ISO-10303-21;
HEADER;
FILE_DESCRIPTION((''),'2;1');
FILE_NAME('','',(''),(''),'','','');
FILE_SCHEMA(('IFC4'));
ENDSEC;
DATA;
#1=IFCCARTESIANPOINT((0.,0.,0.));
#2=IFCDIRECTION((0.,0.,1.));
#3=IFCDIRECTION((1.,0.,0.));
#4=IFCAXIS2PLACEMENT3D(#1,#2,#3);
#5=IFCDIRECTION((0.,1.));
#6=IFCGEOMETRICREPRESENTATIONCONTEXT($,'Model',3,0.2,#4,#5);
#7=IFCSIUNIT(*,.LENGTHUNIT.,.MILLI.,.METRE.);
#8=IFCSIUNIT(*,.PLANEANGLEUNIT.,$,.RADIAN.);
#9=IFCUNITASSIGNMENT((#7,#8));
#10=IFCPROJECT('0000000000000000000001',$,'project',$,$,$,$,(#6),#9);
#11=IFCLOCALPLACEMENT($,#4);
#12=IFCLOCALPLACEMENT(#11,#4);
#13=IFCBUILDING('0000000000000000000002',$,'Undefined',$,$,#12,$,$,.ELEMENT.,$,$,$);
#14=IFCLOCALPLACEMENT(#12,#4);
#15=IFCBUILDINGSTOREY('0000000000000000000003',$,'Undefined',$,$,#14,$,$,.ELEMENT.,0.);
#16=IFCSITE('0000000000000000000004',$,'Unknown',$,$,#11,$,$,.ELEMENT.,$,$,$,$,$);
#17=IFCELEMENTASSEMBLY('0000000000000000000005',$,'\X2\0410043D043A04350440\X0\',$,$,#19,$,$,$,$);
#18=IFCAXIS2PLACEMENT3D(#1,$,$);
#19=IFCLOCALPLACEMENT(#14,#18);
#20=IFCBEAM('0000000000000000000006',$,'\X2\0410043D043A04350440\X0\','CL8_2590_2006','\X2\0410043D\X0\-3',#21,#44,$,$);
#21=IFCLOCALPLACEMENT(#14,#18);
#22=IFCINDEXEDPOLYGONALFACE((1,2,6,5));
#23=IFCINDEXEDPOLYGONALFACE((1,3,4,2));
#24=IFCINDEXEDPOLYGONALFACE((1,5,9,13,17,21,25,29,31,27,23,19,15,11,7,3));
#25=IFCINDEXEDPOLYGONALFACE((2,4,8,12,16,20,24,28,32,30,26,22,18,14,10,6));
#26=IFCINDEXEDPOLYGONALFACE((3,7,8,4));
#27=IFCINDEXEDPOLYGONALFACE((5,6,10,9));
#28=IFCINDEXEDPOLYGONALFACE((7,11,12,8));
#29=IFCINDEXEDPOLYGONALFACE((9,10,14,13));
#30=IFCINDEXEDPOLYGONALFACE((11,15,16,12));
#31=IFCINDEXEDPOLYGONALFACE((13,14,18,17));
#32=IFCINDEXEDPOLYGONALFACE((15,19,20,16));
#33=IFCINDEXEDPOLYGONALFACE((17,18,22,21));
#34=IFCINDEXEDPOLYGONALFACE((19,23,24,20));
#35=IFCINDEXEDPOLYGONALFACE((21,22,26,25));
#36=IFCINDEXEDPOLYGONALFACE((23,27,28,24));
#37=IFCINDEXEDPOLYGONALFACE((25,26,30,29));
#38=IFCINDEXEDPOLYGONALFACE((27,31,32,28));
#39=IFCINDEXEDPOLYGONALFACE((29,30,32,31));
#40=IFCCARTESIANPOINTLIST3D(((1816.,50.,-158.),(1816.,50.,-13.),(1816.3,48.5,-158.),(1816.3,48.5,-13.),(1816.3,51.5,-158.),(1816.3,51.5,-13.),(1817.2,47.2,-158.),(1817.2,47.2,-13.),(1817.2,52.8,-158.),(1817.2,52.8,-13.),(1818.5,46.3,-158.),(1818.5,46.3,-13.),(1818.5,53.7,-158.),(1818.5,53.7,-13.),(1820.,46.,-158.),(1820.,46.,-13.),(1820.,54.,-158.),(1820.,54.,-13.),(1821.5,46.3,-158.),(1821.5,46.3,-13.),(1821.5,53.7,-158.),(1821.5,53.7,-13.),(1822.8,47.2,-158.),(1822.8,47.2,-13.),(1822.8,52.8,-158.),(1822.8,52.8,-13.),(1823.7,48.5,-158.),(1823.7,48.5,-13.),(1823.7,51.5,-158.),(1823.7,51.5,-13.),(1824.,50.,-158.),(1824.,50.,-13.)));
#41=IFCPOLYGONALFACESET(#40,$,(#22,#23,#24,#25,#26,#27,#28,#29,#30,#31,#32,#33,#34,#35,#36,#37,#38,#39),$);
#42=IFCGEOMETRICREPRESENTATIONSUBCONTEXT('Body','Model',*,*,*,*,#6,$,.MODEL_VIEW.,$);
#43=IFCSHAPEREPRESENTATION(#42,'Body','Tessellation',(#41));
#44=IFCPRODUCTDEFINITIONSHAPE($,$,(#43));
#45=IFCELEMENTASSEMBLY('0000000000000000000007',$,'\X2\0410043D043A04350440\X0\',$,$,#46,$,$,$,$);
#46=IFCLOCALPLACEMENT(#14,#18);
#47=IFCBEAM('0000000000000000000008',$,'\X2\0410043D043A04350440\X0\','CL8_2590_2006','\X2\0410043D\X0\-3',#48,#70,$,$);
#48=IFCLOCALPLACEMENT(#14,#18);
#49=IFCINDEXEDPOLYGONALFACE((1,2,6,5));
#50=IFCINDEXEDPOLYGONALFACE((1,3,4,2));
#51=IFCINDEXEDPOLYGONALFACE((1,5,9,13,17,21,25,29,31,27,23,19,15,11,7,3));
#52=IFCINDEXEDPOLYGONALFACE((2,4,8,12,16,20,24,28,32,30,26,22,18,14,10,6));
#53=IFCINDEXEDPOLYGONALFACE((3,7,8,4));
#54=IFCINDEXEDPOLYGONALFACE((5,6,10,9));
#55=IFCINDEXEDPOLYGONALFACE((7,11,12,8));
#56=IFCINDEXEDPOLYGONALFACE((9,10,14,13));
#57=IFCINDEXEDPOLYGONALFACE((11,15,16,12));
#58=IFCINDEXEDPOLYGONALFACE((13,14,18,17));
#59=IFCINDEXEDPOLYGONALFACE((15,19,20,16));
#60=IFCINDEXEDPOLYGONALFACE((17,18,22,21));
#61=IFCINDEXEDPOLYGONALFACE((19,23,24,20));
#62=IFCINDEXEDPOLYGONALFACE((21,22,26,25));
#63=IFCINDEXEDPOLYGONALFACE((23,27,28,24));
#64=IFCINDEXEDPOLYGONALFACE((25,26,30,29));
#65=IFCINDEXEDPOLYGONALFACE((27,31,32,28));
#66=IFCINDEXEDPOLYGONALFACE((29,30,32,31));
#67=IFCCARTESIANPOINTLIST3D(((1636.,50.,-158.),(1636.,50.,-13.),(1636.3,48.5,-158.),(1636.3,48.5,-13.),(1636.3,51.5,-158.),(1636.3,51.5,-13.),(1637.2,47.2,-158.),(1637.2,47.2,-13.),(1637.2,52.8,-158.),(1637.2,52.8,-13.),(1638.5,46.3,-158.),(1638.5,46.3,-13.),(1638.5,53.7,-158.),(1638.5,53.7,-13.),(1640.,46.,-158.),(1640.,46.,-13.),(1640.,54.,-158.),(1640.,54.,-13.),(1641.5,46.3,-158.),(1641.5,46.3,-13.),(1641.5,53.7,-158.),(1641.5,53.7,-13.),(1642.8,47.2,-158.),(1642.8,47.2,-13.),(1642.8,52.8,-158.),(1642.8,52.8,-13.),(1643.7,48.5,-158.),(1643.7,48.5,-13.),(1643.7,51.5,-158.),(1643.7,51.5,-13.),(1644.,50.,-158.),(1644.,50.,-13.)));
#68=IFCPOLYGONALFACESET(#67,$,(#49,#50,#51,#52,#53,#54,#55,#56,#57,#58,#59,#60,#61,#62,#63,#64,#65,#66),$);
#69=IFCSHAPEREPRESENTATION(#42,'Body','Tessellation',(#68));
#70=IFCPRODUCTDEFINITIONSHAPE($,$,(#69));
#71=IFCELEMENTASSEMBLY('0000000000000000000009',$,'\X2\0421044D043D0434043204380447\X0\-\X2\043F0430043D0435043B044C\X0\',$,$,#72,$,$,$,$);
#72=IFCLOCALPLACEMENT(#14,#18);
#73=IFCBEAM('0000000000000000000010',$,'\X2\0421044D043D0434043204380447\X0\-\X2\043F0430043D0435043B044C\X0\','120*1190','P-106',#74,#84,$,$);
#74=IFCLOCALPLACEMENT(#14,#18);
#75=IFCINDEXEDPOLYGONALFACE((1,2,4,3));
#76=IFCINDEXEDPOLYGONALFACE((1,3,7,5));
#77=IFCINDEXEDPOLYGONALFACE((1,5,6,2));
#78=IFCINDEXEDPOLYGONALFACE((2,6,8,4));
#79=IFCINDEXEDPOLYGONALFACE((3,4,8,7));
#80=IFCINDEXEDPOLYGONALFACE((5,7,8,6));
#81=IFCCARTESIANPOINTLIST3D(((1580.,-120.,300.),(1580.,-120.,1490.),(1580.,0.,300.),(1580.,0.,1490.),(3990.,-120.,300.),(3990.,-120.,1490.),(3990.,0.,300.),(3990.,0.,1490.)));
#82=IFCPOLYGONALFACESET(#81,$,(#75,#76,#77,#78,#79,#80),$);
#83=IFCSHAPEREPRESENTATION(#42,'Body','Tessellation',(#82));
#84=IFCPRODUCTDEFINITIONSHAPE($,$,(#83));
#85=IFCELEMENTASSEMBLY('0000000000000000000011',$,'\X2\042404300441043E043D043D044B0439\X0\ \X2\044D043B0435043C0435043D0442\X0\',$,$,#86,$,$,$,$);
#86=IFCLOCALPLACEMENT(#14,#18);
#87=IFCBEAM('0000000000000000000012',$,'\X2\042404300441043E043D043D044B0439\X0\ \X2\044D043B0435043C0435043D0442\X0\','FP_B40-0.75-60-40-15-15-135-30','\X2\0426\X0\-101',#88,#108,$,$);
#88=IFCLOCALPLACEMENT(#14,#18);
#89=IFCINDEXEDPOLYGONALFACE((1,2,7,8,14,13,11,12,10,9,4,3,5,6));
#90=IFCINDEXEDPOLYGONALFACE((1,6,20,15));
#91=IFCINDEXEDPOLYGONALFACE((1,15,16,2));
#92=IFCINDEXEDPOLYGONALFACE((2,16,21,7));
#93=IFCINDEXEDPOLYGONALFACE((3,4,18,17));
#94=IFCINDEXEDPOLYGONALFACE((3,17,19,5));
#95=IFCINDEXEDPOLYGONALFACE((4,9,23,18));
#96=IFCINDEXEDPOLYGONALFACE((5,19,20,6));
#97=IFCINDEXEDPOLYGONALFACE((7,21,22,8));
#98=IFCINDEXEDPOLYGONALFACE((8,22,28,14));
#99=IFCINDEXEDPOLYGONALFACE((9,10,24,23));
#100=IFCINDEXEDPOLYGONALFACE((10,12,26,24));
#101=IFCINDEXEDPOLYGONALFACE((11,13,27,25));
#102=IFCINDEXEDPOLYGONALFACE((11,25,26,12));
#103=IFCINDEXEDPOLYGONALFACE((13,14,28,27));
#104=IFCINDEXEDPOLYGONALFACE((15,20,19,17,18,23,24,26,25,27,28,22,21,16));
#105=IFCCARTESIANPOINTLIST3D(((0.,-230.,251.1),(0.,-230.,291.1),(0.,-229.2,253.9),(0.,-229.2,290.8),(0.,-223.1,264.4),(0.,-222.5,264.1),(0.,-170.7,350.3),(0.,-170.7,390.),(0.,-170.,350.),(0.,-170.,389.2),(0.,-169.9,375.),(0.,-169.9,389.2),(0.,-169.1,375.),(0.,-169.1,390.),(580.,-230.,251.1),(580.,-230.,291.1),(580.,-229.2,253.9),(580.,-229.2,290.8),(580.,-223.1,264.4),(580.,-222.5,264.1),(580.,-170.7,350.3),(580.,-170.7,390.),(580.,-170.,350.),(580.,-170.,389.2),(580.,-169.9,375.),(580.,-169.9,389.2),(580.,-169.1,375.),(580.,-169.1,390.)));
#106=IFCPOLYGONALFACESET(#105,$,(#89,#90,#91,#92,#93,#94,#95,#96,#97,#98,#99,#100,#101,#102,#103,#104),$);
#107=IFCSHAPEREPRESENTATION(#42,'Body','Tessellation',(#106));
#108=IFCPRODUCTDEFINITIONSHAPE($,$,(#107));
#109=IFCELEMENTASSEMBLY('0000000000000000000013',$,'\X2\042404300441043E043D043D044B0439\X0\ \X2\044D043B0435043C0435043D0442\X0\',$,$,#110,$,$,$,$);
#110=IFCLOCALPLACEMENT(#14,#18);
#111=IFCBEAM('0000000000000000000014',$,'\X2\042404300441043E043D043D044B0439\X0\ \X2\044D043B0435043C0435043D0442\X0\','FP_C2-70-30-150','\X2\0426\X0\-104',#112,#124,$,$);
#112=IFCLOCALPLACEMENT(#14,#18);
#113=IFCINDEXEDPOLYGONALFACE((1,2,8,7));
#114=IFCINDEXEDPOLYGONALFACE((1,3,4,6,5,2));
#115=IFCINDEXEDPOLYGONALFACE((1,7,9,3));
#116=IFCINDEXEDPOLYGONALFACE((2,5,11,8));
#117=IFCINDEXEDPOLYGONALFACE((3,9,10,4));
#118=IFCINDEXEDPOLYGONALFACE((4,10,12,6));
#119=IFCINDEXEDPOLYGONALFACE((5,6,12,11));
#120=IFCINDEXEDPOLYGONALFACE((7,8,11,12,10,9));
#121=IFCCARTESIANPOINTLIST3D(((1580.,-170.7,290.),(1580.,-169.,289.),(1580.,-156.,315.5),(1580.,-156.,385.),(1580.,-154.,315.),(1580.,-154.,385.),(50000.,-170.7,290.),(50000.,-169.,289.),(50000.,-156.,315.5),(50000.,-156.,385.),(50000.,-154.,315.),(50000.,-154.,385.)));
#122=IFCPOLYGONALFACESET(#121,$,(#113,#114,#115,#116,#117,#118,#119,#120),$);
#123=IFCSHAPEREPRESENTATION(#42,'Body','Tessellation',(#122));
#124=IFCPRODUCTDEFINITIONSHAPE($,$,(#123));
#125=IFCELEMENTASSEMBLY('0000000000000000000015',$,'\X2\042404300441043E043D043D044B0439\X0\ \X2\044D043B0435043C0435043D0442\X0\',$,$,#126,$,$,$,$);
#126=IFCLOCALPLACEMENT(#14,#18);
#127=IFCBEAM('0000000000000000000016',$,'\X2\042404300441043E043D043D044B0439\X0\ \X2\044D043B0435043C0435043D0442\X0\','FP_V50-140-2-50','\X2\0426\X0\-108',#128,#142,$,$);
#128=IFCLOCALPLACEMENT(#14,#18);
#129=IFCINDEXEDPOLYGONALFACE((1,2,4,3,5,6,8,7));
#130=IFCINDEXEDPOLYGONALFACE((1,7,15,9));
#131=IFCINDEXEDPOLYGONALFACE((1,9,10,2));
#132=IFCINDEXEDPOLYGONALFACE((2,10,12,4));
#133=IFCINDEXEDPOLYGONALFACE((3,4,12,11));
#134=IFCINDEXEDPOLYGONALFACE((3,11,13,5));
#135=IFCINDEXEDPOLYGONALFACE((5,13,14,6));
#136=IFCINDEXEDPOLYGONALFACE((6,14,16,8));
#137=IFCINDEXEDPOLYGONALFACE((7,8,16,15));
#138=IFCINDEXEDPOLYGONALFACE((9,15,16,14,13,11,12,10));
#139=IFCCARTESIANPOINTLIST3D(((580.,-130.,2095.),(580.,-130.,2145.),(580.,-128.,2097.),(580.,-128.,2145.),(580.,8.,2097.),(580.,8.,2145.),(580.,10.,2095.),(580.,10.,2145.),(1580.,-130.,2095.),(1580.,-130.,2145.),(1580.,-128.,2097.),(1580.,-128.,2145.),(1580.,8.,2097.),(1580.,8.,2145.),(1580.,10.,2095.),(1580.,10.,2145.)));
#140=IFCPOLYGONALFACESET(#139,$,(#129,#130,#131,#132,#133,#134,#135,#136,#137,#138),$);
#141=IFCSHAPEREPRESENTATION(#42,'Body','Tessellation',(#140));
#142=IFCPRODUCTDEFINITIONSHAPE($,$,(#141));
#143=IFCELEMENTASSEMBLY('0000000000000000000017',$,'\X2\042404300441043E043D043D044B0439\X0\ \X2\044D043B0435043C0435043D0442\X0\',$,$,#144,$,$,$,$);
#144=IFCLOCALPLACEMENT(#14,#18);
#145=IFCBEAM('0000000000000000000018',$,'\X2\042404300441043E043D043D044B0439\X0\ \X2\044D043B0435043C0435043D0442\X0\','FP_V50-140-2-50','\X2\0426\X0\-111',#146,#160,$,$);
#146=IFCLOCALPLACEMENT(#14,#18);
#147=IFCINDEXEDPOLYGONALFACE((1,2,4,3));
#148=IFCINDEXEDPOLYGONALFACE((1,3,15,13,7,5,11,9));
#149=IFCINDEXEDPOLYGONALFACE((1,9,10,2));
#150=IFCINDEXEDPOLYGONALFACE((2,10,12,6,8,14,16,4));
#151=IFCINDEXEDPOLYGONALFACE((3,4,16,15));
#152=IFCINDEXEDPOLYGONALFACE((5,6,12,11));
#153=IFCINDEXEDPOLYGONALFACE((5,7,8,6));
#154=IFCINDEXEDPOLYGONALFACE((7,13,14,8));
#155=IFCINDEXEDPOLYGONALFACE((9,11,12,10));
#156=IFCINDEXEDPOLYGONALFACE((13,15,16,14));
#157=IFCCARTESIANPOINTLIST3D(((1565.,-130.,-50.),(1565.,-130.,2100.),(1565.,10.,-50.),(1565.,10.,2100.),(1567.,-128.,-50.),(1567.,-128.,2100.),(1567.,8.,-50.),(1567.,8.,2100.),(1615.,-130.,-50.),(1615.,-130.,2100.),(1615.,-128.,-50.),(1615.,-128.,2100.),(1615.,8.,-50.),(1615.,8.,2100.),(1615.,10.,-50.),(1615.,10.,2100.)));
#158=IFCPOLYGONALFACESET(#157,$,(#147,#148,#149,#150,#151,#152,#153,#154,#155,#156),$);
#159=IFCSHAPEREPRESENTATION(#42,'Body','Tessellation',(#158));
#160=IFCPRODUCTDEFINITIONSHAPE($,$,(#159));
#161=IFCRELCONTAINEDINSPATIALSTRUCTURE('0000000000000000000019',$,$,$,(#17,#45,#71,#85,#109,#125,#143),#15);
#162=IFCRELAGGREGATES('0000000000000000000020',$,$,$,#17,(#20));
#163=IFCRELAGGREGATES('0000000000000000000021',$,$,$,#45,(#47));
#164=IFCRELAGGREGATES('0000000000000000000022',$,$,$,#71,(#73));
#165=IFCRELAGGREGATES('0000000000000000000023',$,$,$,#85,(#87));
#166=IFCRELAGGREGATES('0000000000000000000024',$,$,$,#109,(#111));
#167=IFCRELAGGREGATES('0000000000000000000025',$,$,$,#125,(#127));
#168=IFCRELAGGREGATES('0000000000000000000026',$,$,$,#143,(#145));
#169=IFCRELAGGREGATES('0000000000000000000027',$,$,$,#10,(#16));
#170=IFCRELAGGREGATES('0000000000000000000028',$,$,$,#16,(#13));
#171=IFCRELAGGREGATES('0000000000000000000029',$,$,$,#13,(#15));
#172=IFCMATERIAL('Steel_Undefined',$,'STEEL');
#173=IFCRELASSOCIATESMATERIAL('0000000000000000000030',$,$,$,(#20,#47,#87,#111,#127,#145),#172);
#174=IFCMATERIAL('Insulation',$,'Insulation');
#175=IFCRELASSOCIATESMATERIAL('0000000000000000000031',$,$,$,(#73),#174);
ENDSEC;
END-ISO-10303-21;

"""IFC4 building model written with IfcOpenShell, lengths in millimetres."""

from ifc_helpers import new_model, si_unit, direction, frame, origin_with_axes, place, context, subcontext, project, spatial, line, indexed_curve, outline, extrude, material, element, aggregate, save


model = new_model("IFC4")

# Units and contexts
model_context = context("Model", 3, precision=0.2, world=origin_with_axes(), true_north=direction((0.0, 1.0)))
body_context = subcontext(model_context, "Body", "Model", "MODEL_VIEW")
ifc_project = project(units=[si_unit("LENGTHUNIT", "METRE", prefix="MILLI"), si_unit("PLANEANGLEUNIT", "RADIAN")], contexts=[model_context])

# Site, building, storey
site_placement = place(None, origin_with_axes())
site = spatial("IfcSite", under=ifc_project, at=site_placement, Name="Unknown", CompositionType="ELEMENT")
building_placement = place(site_placement, origin_with_axes())
building = spatial("IfcBuilding", under=site, at=building_placement, Name="Undefined", CompositionType="ELEMENT")
storey_placement = place(building_placement, origin_with_axes())
storey = spatial("IfcBuildingStorey", under=building, at=storey_placement, Name="Undefined", CompositionType="ELEMENT", Elevation=0.0)

# Shared definitions
ifc_material_1 = material(Name="Steel_Undefined", Category="STEEL")

# Element assemblies, beams
assembly_1_placement = place(storey_placement, frame((1820.0, 50.0, -13.0), z_axis=(1.0, 0.0, 0.0), x_axis=(0.0, 0.0, -1.0)))
assembly_1 = element("IfcElementAssembly", 1, at=assembly_1_placement, inside=storey, Name="Анкер")
beam_1_placement = place(assembly_1_placement, origin_with_axes())
beam_1 = element("IfcBeam", 2, at=beam_1_placement, material=ifc_material_1, Name="Анкер", Description="CL8_2590_2006", ObjectType="Ан-3", context=body_context, shape_type="SolidModel", body=[
    extrude(outline(indexed_curve([(4.0, 0.0), (3.7, 1.5), (2.8, 2.8), (1.5, 3.7), (0.0, 4.0), (-1.5, 3.7), (-2.8, 2.8), (-3.7, 1.5), (-4.0, 0.0), (-3.7, -1.5), (-2.8, -2.8), (-1.5, -3.7), (0.0, -4.0), (1.5, -3.7), (2.8, -2.8), (3.7, -1.5)], segments=[line(1, 2, 3, 4, 5, 6, 7, 8, 9, 10, 11, 12, 13, 14, 15, 16, 1)])), frame((0.0, 0.0, 0.0), z_axis=(-1.0, 0.0, 0.0), x_axis=(0.0, 0.0, 1.0)), (0.0, 0.0, -1.0), 145.0),
])
aggregate(assembly_1, [beam_1])
assembly_2_placement = place(storey_placement, frame((1640.0, 50.0, -13.0), z_axis=(1.0, 0.0, 0.0), x_axis=(0.0, 0.0, -1.0)))
assembly_2 = element("IfcElementAssembly", 3, at=assembly_2_placement, inside=storey, Name="Анкер")
beam_2_placement = place(assembly_2_placement, origin_with_axes())
beam_2 = element("IfcBeam", 4, at=beam_2_placement, material=ifc_material_1, Name="Анкер", Description="CL8_2590_2006", ObjectType="Ан-3", context=body_context, shape_type="SolidModel", body=[
    extrude(outline(indexed_curve([(4.0, 0.0), (3.7, 1.5), (2.8, 2.8), (1.5, 3.7), (0.0, 4.0), (-1.5, 3.7), (-2.8, 2.8), (-3.7, 1.5), (-4.0, 0.0), (-3.7, -1.5), (-2.8, -2.8), (-1.5, -3.7), (0.0, -4.0), (1.5, -3.7), (2.8, -2.8), (3.7, -1.5)], segments=[line(1, 2, 3, 4, 5, 6, 7, 8, 9, 10, 11, 12, 13, 14, 15, 16, 1)])), frame((0.0, 0.0, 0.0), z_axis=(-1.0, 0.0, 0.0), x_axis=(0.0, 0.0, 1.0)), (0.0, 0.0, -1.0), 145.0),
])
aggregate(assembly_2, [beam_2])
assembly_3_placement = place(storey_placement, frame((1580.0, -60.0, 895.0), z_axis=(0.0, 0.0, -1.0), x_axis=(1.0, 0.0, 0.0)))
assembly_3 = element("IfcElementAssembly", 5, at=assembly_3_placement, inside=storey, Name="Сэндвич-панель")
ifc_material_2 = material(Name="Insulation", Category="Insulation")
beam_3_placement = place(assembly_3_placement, origin_with_axes())
beam_3 = element("IfcBeam", 6, at=beam_3_placement, material=ifc_material_2, Name="Сэндвич-панель", Description="120*1190", ObjectType="P-106", context=body_context, shape_type="SolidModel", body=[
    extrude(outline(indexed_curve([(-595.0, -60.0), (595.0, -60.0), (595.0, 60.0), (-595.0, 60.0)], segments=[line(1, 2, 3, 4, 1)])), frame((0.0, 0.0, 0.0), z_axis=(-1.0, 0.0, 0.0), x_axis=(0.0, 0.0, 1.0)), (0.0, 0.0, -1.0), 2410.0),
])
aggregate(assembly_3, [beam_3])
assembly_4_placement = place(storey_placement, frame((580.0, -170.4, 370.0), z_axis=(0.0, 1.0, 0.0), x_axis=(-1.0, 0.0, 0.0)))
assembly_4 = element("IfcElementAssembly", 7, at=assembly_4_placement, inside=storey, Name="Фасонный элемент")
beam_4_placement = place(assembly_4_placement, origin_with_axes())
beam_4 = element("IfcBeam", 8, at=beam_4_placement, material=ifc_material_1, Name="Фасонный элемент", Description="FP_B40-0.75-60-40-15-15-135-30", ObjectType="Ц-101", context=body_context, shape_type="SolidModel", body=[
    extrude(outline(indexed_curve([(0.4, -20.0), (0.4, 19.2), (0.5, 19.2), (0.5, 5.0), (1.2, 5.0), (1.2, 20.0), (-0.4, 20.0), (-0.4, -19.7), (-59.6, -78.9), (-59.6, -118.9), (-52.1, -105.9), (-52.8, -105.6), (-58.9, -116.1), (-58.9, -79.2)], segments=[line(1, 2, 3, 4, 5, 6, 7, 8, 9, 10, 11, 12, 13, 14, 1)])), frame((0.0, 0.0, 0.0), z_axis=(-1.0, 0.0, 0.0), x_axis=(0.0, 0.0, 1.0)), (0.0, 0.0, -1.0), 580.0),
])
aggregate(assembly_4, [beam_4])
assembly_5_placement = place(storey_placement, frame((1580.0, -155.0, 350.0), z_axis=(0.0, 0.0, -1.0), x_axis=(1.0, 0.0, 0.0)))
assembly_5 = element("IfcElementAssembly", 9, at=assembly_5_placement, inside=storey, Name="Фасонный элемент")
beam_5_placement = place(assembly_5_placement, origin_with_axes())
beam_5 = element("IfcBeam", 10, at=beam_5_placement, material=ifc_material_1, Name="Фасонный элемент", Description="FP_C2-70-30-150", ObjectType="Ц-104", context=body_context, shape_type="SolidModel", body=[
    extrude(outline(indexed_curve([(-35.0, -1.0), (35.0, -1.0), (61.0, 14.0), (60.0, 15.7), (34.5, 1.0), (-35.0, 1.0)], segments=[line(1, 2, 3, 4, 5, 6, 1)])), frame((0.0, 0.0, 0.0), z_axis=(-1.0, 0.0, 0.0), x_axis=(0.0, 0.0, 1.0)), (0.0, 0.0, -1.0), 48420.0),
])
aggregate(assembly_5, [beam_5])
assembly_6_placement = place(storey_placement, frame((580.0, -60.0, 2120.0), z_axis=(0.0, 1.0, 0.0), x_axis=(1.0, 0.0, 0.0)))
assembly_6 = element("IfcElementAssembly", 11, at=assembly_6_placement, inside=storey, Name="Фасонный элемент")
beam_6_placement = place(assembly_6_placement, origin_with_axes())
beam_6 = element("IfcBeam", 12, at=beam_6_placement, material=ifc_material_1, Name="Фасонный элемент", Description="FP_V50-140-2-50", ObjectType="Ц-108", context=body_context, shape_type="SolidModel", body=[
    extrude(outline(indexed_curve([(-70.0, -25.0), (-68.0, -25.0), (-68.0, 23.0), (68.0, 23.0), (68.0, -25.0), (70.0, -25.0), (70.0, 25.0), (-70.0, 25.0)], segments=[line(1, 2, 3, 4, 5, 6, 7, 8, 1)])), frame((0.0, 0.0, 0.0), z_axis=(-1.0, 0.0, 0.0), x_axis=(0.0, 0.0, 1.0)), (0.0, 0.0, -1.0), 1000.0),
])
aggregate(assembly_6, [beam_6])
assembly_7_placement = place(storey_placement, frame((1590.0, -60.0, 2100.0), z_axis=(0.0, 1.0, 0.0), x_axis=(0.0, 0.0, -1.0)))
assembly_7 = element("IfcElementAssembly", 13, at=assembly_7_placement, inside=storey, Name="Фасонный элемент")
beam_7_placement = place(assembly_7_placement, origin_with_axes())
beam_7 = element("IfcBeam", 14, at=beam_7_placement, material=ifc_material_1, Name="Фасонный элемент", Description="FP_V50-140-2-50", ObjectType="Ц-111", context=body_context, shape_type="SolidModel", body=[
    extrude(outline(indexed_curve([(-70.0, -25.0), (-68.0, -25.0), (-68.0, 23.0), (68.0, 23.0), (68.0, -25.0), (70.0, -25.0), (70.0, 25.0), (-70.0, 25.0)], segments=[line(1, 2, 3, 4, 5, 6, 7, 8, 1)])), frame((0.0, 0.0, 0.0), z_axis=(-1.0, 0.0, 0.0), x_axis=(0.0, 0.0, 1.0)), (0.0, 0.0, -1.0), 2150.0),
])
aggregate(assembly_7, [beam_7])

save(model, "model.ifc")
